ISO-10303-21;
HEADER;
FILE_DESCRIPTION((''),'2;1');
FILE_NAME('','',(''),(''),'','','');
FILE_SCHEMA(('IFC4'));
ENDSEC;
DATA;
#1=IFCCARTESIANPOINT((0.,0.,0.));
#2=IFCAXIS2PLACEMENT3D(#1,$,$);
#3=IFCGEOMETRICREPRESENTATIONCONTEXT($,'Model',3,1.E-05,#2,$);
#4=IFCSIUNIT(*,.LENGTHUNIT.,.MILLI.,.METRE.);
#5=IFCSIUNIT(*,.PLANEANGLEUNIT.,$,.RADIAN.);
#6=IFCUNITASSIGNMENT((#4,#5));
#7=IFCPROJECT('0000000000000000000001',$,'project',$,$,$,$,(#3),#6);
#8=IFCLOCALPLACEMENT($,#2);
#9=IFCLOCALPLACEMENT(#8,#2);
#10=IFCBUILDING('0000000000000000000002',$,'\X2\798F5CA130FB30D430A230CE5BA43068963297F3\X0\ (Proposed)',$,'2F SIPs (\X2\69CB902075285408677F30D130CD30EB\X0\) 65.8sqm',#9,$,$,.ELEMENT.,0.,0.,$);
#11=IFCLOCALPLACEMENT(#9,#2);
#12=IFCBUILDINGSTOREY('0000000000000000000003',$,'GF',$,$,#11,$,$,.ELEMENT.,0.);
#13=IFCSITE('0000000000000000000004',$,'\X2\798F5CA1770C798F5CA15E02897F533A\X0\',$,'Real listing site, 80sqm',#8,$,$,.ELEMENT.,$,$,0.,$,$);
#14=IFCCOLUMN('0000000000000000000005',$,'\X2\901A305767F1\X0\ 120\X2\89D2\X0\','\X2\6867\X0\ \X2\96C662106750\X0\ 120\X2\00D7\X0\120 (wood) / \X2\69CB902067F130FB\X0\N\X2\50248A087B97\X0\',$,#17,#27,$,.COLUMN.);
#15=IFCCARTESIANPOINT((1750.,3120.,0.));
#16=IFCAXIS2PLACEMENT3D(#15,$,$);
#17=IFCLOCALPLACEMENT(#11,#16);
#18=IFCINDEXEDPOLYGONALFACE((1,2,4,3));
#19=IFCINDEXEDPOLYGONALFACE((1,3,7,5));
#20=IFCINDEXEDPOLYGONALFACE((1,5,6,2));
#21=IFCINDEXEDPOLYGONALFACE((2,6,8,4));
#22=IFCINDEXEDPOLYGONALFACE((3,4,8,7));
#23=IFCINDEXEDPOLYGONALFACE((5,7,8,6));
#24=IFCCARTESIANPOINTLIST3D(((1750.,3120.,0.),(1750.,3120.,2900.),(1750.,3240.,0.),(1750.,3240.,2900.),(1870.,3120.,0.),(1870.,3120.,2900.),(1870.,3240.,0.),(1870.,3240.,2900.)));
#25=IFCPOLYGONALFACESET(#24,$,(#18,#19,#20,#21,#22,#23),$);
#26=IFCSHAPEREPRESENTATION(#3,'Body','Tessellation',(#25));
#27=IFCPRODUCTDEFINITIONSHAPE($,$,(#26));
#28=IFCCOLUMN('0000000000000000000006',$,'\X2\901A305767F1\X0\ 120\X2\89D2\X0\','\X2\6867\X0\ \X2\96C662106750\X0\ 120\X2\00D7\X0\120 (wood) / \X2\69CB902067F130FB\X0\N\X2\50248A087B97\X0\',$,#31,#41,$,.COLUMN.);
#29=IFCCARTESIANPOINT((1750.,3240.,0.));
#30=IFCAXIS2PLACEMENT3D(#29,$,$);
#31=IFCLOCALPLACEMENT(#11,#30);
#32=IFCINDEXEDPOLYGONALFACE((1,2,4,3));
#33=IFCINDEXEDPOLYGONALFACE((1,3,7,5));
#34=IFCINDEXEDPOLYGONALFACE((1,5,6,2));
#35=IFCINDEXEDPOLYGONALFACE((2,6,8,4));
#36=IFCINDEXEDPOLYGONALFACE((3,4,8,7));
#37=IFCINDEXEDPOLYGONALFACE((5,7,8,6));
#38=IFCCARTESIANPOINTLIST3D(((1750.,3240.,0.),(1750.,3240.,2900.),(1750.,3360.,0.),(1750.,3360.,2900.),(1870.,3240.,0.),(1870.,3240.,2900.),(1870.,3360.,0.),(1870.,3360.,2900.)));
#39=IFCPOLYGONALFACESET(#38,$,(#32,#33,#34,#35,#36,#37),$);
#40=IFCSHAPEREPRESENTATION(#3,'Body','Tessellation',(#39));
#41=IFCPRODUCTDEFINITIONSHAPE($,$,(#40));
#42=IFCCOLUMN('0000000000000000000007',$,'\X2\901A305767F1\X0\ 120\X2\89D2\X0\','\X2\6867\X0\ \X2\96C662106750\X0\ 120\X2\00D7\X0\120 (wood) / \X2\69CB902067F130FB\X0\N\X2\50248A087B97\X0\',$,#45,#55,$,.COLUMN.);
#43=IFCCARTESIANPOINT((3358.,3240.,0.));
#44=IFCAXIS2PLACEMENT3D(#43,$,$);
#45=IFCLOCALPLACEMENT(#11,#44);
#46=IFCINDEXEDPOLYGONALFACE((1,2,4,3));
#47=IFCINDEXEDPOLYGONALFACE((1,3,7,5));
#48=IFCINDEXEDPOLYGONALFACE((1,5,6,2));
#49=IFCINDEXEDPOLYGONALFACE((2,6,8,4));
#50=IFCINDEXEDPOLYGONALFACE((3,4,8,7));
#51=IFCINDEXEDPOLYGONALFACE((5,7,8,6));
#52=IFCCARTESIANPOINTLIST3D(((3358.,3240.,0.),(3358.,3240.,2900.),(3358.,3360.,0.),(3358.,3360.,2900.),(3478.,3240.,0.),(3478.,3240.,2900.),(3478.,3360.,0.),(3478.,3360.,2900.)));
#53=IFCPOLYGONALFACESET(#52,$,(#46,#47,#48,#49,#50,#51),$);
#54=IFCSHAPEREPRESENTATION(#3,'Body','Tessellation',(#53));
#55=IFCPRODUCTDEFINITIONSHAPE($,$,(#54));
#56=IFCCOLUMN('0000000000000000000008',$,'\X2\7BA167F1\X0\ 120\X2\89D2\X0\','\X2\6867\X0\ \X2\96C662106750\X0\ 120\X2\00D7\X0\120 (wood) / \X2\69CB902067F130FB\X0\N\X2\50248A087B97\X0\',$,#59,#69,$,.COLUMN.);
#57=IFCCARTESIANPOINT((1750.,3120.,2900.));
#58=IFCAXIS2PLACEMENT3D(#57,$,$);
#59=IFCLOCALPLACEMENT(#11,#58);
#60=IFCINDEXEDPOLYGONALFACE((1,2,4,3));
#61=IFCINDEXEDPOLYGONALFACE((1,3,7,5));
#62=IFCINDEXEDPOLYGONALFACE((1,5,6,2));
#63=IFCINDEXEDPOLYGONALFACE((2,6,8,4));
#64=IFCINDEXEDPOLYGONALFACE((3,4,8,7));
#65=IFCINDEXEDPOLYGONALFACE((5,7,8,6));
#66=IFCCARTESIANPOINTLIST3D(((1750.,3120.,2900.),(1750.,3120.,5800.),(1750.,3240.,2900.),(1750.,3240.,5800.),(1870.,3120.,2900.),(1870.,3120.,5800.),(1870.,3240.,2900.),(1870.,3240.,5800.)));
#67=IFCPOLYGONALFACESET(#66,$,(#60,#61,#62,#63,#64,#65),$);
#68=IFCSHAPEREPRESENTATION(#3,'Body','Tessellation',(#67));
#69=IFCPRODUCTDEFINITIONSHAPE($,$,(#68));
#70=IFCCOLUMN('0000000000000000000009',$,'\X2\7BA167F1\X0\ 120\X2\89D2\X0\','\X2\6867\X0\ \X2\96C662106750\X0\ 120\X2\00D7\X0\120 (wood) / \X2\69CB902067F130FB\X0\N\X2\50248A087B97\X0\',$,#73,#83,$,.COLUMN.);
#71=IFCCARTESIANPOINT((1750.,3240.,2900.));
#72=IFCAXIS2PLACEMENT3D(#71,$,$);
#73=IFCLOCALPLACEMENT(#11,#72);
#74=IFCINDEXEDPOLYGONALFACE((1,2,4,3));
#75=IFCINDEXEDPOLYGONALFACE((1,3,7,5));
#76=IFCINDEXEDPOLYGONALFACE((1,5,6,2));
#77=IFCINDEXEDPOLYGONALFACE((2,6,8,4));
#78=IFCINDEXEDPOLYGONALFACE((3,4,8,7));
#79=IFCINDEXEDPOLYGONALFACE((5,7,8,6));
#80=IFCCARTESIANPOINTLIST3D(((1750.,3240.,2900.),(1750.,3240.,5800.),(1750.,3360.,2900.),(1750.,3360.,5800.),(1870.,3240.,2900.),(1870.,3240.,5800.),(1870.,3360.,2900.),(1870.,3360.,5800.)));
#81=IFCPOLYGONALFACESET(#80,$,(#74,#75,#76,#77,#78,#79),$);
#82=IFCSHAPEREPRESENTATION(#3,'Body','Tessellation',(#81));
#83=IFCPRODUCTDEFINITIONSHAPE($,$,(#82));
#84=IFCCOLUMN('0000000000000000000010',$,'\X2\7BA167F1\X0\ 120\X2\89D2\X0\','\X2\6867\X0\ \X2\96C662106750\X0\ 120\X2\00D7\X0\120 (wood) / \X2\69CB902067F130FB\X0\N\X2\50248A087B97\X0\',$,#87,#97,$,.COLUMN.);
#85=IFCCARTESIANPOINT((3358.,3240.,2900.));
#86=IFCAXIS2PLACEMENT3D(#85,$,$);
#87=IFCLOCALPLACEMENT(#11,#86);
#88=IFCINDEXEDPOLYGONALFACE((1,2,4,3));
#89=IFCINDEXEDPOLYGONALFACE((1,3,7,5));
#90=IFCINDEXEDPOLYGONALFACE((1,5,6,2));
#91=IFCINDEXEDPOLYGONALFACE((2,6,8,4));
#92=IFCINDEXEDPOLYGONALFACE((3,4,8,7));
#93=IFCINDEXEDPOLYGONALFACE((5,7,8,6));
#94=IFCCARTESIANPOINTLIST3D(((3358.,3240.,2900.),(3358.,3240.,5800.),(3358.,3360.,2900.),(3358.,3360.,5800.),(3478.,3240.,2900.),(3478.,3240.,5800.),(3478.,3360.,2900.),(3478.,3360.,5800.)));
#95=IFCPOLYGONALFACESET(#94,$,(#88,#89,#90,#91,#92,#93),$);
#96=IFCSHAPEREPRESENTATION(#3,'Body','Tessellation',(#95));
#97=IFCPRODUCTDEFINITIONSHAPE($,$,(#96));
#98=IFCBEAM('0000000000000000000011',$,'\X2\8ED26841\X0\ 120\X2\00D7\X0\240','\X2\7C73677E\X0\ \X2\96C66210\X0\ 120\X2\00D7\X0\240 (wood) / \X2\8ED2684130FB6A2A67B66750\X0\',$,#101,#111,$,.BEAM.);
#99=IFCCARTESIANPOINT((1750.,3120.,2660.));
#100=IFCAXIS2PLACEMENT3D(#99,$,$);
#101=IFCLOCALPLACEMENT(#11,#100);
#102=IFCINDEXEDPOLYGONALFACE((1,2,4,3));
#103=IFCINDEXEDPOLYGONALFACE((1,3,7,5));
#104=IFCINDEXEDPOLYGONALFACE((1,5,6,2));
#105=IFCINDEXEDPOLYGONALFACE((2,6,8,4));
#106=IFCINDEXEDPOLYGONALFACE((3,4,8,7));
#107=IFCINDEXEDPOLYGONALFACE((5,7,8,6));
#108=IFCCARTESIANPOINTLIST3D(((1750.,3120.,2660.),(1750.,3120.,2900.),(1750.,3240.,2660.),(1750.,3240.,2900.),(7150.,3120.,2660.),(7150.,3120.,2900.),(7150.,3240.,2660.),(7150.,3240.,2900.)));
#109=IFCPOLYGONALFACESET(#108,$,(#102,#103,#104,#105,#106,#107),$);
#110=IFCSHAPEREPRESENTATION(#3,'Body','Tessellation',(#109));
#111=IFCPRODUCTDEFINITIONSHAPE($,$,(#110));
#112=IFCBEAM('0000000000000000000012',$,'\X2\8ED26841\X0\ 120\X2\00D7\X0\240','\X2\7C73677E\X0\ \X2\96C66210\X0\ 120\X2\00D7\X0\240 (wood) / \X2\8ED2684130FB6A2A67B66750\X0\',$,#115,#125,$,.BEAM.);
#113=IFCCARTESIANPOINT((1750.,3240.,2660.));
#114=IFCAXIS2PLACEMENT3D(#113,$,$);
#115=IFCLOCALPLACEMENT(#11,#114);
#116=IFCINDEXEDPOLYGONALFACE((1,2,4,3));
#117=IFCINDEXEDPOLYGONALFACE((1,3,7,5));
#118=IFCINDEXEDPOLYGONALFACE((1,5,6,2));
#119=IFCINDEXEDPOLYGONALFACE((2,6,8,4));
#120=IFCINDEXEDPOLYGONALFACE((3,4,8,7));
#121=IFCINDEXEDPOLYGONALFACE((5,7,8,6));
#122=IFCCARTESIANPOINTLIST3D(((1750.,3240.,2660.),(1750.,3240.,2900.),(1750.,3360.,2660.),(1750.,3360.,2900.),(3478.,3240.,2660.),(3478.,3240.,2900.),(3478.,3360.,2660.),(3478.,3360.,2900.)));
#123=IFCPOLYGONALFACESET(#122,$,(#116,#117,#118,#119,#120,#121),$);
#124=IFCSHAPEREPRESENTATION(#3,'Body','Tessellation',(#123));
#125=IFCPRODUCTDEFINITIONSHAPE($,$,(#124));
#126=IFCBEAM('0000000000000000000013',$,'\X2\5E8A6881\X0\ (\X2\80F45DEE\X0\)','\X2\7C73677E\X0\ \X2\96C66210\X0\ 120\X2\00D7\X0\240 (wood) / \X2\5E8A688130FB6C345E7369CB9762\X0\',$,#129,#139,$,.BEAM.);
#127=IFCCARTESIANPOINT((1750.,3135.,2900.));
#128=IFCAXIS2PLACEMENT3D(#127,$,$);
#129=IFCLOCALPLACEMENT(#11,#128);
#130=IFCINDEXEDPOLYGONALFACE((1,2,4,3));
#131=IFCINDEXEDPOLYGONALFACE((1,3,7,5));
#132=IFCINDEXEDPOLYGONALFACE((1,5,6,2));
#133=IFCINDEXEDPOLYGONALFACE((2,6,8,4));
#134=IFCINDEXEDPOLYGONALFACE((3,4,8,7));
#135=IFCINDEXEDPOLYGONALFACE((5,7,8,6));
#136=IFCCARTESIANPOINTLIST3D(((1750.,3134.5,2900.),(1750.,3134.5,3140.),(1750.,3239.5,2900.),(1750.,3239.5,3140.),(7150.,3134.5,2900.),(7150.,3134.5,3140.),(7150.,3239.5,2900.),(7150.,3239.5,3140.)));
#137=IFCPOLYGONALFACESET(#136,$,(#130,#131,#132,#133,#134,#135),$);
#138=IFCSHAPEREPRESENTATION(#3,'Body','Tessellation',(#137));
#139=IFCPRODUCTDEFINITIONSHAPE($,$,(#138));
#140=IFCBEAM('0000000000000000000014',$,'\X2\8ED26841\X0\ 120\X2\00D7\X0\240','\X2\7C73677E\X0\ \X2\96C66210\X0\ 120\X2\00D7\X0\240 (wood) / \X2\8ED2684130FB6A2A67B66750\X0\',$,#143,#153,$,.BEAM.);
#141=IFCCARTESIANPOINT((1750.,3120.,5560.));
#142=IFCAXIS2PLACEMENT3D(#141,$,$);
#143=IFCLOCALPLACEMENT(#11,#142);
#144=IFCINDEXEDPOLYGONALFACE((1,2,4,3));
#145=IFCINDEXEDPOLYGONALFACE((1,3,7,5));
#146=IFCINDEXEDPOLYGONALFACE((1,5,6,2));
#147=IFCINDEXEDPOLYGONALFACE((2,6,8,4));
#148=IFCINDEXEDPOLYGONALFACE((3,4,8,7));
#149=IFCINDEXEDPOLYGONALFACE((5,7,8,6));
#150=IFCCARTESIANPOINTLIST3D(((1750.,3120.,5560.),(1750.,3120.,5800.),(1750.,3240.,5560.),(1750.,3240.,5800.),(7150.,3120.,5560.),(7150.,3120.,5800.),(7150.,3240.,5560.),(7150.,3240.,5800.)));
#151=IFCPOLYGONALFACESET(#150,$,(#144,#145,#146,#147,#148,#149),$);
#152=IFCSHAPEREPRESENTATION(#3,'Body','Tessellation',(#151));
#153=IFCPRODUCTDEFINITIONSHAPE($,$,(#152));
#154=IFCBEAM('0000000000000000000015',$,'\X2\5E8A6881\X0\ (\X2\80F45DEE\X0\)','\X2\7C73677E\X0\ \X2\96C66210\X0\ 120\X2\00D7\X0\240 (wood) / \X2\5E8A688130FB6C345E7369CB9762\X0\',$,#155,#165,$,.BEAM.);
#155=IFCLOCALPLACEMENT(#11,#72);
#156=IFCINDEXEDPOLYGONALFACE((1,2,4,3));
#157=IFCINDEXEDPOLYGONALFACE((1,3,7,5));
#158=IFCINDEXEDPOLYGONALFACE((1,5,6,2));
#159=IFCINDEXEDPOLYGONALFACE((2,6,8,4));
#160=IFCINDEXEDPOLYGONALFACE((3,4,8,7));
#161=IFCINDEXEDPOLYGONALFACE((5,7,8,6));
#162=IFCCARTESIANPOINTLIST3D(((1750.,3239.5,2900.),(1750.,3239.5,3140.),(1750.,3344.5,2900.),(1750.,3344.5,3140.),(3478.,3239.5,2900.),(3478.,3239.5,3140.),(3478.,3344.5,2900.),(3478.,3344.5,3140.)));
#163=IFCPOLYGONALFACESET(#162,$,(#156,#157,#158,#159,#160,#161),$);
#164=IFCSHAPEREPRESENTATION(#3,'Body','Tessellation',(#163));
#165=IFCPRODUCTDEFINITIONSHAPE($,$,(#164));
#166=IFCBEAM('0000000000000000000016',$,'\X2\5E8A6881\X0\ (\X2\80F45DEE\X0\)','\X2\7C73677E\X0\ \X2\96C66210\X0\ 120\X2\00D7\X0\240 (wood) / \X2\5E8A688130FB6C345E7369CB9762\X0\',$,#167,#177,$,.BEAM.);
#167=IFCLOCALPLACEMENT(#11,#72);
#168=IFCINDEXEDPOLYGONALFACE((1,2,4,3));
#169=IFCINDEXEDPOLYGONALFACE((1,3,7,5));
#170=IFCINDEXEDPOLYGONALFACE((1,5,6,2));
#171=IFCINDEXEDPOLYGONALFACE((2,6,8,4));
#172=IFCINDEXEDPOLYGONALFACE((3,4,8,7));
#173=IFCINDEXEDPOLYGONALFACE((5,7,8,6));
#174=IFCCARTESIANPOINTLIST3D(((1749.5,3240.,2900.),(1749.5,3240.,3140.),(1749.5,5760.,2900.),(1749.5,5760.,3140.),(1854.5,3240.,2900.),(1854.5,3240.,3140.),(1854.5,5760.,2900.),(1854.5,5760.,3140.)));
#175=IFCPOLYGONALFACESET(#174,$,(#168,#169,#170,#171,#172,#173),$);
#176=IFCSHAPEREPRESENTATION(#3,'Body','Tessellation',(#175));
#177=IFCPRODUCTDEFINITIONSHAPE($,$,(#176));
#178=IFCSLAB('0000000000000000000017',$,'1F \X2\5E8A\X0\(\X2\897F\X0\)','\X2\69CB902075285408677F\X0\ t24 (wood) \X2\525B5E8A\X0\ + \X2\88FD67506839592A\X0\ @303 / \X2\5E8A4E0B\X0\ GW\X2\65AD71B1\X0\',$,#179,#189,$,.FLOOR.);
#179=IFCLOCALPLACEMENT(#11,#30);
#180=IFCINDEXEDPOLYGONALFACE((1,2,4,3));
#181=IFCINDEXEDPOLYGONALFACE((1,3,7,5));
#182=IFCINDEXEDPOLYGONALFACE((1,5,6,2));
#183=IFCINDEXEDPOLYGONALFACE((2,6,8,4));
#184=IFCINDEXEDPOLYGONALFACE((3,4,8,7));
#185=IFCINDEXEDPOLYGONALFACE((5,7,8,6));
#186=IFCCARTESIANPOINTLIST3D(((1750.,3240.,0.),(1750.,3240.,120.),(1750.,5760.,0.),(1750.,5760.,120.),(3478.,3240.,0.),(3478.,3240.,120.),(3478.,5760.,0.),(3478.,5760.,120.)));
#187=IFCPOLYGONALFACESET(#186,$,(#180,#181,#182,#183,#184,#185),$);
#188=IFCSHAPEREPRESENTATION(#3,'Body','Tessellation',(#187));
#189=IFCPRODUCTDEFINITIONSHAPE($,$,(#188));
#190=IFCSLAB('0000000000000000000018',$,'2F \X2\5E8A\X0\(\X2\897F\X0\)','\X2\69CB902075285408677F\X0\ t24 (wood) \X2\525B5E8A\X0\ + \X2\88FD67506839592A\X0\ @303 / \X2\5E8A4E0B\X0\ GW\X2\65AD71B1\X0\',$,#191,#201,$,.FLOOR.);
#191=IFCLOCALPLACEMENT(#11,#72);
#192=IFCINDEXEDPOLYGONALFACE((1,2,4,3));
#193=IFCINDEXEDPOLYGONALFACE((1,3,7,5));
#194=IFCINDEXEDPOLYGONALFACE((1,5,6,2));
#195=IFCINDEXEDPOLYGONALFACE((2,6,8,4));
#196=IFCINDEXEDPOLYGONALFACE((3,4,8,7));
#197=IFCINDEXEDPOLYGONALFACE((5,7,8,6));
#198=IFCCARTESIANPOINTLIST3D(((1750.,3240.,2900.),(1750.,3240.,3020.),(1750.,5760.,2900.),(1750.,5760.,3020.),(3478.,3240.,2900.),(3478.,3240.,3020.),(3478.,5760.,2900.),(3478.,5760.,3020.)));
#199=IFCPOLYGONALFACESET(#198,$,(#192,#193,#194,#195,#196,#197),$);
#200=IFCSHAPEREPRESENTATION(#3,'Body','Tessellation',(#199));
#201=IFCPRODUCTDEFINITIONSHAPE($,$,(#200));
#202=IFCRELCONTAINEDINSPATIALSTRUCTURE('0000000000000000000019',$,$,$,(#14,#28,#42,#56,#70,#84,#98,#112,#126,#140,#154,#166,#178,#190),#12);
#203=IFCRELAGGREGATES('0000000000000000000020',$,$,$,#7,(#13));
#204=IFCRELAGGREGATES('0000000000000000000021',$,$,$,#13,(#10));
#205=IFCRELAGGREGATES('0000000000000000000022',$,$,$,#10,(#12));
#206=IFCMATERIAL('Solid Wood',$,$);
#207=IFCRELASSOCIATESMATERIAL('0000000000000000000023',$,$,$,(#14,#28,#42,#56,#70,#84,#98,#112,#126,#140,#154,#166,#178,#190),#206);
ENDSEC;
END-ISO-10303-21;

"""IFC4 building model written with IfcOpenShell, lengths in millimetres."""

from ifc_helpers import new_model, si_unit, frame, frame_2d, origin, place, context, project, spatial, rectangle, extrude, material, element, save


model = new_model("IFC4")

# Units and contexts
model_context = context("Model", 3, precision=1e-05, world=origin())
ifc_project = project(units=[si_unit("LENGTHUNIT", "METRE", prefix="MILLI"), si_unit("PLANEANGLEUNIT", "RADIAN")], contexts=[model_context])

# Site, building, storey
site_placement = place(None, origin())
site = spatial("IfcSite", under=ifc_project, at=site_placement, Name="福岡県福岡市西区", ObjectType="Real listing site, 80sqm", CompositionType="ELEMENT", RefElevation=0.0)
building_placement = place(site_placement, origin())
building = spatial("IfcBuilding", under=site, at=building_placement, Name="福岡・ピアノ室と防音 (Proposed)", ObjectType="2F SIPs (構造用合板パネル) 65.8sqm", CompositionType="ELEMENT", ElevationOfRefHeight=0.0, ElevationOfTerrain=0.0)
storey_placement = place(building_placement, origin())
storey = spatial("IfcBuildingStorey", under=building, at=storey_placement, Name="GF", CompositionType="ELEMENT", Elevation=0.0)

# Columns
ifc_material_1 = material(Name="Solid Wood")
column_1_placement = place(storey_placement, frame((1750.0, 3120.0, 0.0)))
element("IfcColumn", 1, at=column_1_placement, inside=storey, material=ifc_material_1, Name="通し柱 120角", Description="桧 集成材 120×120 (wood) / 構造柱・N値計算", PredefinedType="COLUMN", context=model_context, shape_type="SweptSolid", body=[
    extrude(rectangle(XDim=120.0, YDim=120.0, at=frame_2d((60.0, 60.0))), frame((1750.0, 3120.0, 0.0)), (0.0, 0.0, 1.0), 2900.0),
])
column_2_placement = place(storey_placement, frame((1750.0, 3240.0, 0.0)))
element("IfcColumn", 2, at=column_2_placement, inside=storey, material=ifc_material_1, Name="通し柱 120角", Description="桧 集成材 120×120 (wood) / 構造柱・N値計算", PredefinedType="COLUMN", context=model_context, shape_type="SweptSolid", body=[
    extrude(rectangle(XDim=120.0, YDim=120.0, at=frame_2d((60.0, 60.0))), frame((1750.0, 3240.0, 0.0)), (0.0, 0.0, 1.0), 2900.0),
])
column_3_placement = place(storey_placement, frame((3358.0, 3240.0, 0.0)))
element("IfcColumn", 3, at=column_3_placement, inside=storey, material=ifc_material_1, Name="通し柱 120角", Description="桧 集成材 120×120 (wood) / 構造柱・N値計算", PredefinedType="COLUMN", context=model_context, shape_type="SweptSolid", body=[
    extrude(rectangle(XDim=120.0, YDim=120.0, at=frame_2d((60.0, 60.0))), frame((3358.0, 3240.0, 0.0)), (0.0, 0.0, 1.0), 2900.0),
])
column_4_placement = place(storey_placement, frame((1750.0, 3120.0, 2900.0)))
element("IfcColumn", 4, at=column_4_placement, inside=storey, material=ifc_material_1, Name="管柱 120角", Description="桧 集成材 120×120 (wood) / 構造柱・N値計算", PredefinedType="COLUMN", context=model_context, shape_type="SweptSolid", body=[
    extrude(rectangle(XDim=120.0, YDim=120.0, at=frame_2d((60.0, 60.0))), frame((1750.0, 3120.0, 2900.0)), (0.0, 0.0, 1.0), 2900.0),
])
column_5_placement = place(storey_placement, frame((1750.0, 3240.0, 2900.0)))
element("IfcColumn", 5, at=column_5_placement, inside=storey, material=ifc_material_1, Name="管柱 120角", Description="桧 集成材 120×120 (wood) / 構造柱・N値計算", PredefinedType="COLUMN", context=model_context, shape_type="SweptSolid", body=[
    extrude(rectangle(XDim=120.0, YDim=120.0, at=frame_2d((60.0, 60.0))), frame((1750.0, 3240.0, 2900.0)), (0.0, 0.0, 1.0), 2900.0),
])
column_6_placement = place(storey_placement, frame((3358.0, 3240.0, 2900.0)))
element("IfcColumn", 6, at=column_6_placement, inside=storey, material=ifc_material_1, Name="管柱 120角", Description="桧 集成材 120×120 (wood) / 構造柱・N値計算", PredefinedType="COLUMN", context=model_context, shape_type="SweptSolid", body=[
    extrude(rectangle(XDim=120.0, YDim=120.0, at=frame_2d((60.0, 60.0))), frame((3358.0, 3240.0, 2900.0)), (0.0, 0.0, 1.0), 2900.0),
])

# Beams
beam_1_placement = place(storey_placement, frame((1750.0, 3120.0, 2660.0)))
element("IfcBeam", 7, at=beam_1_placement, inside=storey, material=ifc_material_1, Name="軒桁 120×240", Description="米松 集成 120×240 (wood) / 軒桁・横架材", PredefinedType="BEAM", context=model_context, shape_type="SweptSolid", body=[
    extrude(rectangle(XDim=5400.0, YDim=120.0, at=frame_2d((2700.0, 60.0))), frame((1750.0, 3120.0, 2660.0)), (0.0, 0.0, 1.0), 240.0),
])
beam_2_placement = place(storey_placement, frame((1750.0, 3240.0, 2660.0)))
element("IfcBeam", 8, at=beam_2_placement, inside=storey, material=ifc_material_1, Name="軒桁 120×240", Description="米松 集成 120×240 (wood) / 軒桁・横架材", PredefinedType="BEAM", context=model_context, shape_type="SweptSolid", body=[
    extrude(rectangle(XDim=1728.0, YDim=120.0, at=frame_2d((864.0, 60.0))), frame((1750.0, 3240.0, 2660.0)), (0.0, 0.0, 1.0), 240.0),
])
beam_3_placement = place(storey_placement, frame((1750.0, 3135.0, 2900.0)))
element("IfcBeam", 9, at=beam_3_placement, inside=storey, material=ifc_material_1, Name="床梁 (胴差)", Description="米松 集成 120×240 (wood) / 床梁・水平構面", PredefinedType="BEAM", context=model_context, shape_type="SweptSolid", body=[
    extrude(rectangle(XDim=5400.0, YDim=105.0, at=frame_2d((2700.0, 52.0))), frame((1750.0, 3135.0, 2900.0)), (0.0, 0.0, 1.0), 240.0),
])
beam_4_placement = place(storey_placement, frame((1750.0, 3120.0, 5560.0)))
element("IfcBeam", 10, at=beam_4_placement, inside=storey, material=ifc_material_1, Name="軒桁 120×240", Description="米松 集成 120×240 (wood) / 軒桁・横架材", PredefinedType="BEAM", context=model_context, shape_type="SweptSolid", body=[
    extrude(rectangle(XDim=5400.0, YDim=120.0, at=frame_2d((2700.0, 60.0))), frame((1750.0, 3120.0, 5560.0)), (0.0, 0.0, 1.0), 240.0),
])
beam_5_placement = place(storey_placement, frame((1750.0, 3240.0, 2900.0)))
element("IfcBeam", 11, at=beam_5_placement, inside=storey, material=ifc_material_1, Name="床梁 (胴差)", Description="米松 集成 120×240 (wood) / 床梁・水平構面", PredefinedType="BEAM", context=model_context, shape_type="SweptSolid", body=[
    extrude(rectangle(XDim=1728.0, YDim=105.0, at=frame_2d((864.0, 52.0))), frame((1750.0, 3240.0, 2900.0)), (0.0, 0.0, 1.0), 240.0),
])
beam_6_placement = place(storey_placement, frame((1750.0, 3240.0, 2900.0)))
element("IfcBeam", 12, at=beam_6_placement, inside=storey, material=ifc_material_1, Name="床梁 (胴差)", Description="米松 集成 120×240 (wood) / 床梁・水平構面", PredefinedType="BEAM", context=model_context, shape_type="SweptSolid", body=[
    extrude(rectangle(XDim=105.0, YDim=2520.0, at=frame_2d((52.0, 1260.0))), frame((1750.0, 3240.0, 2900.0)), (0.0, 0.0, 1.0), 240.0),
])

# Slabs
slab_1_placement = place(storey_placement, frame((1750.0, 3240.0, 0.0)))
element("IfcSlab", 13, at=slab_1_placement, inside=storey, material=ifc_material_1, Name="1F 床(西)", Description="構造用合板 t24 (wood) 剛床 + 製材根太 @303 / 床下 GW断熱", PredefinedType="FLOOR", context=model_context, shape_type="SweptSolid", body=[
    extrude(rectangle(XDim=1728.0, YDim=2520.0, at=frame_2d((864.0, 1260.0))), frame((1750.0, 3240.0, 0.0)), (0.0, 0.0, 1.0), 120.0),
])
slab_2_placement = place(storey_placement, frame((1750.0, 3240.0, 2900.0)))
element("IfcSlab", 14, at=slab_2_placement, inside=storey, material=ifc_material_1, Name="2F 床(西)", Description="構造用合板 t24 (wood) 剛床 + 製材根太 @303 / 床下 GW断熱", PredefinedType="FLOOR", context=model_context, shape_type="SweptSolid", body=[
    extrude(rectangle(XDim=1728.0, YDim=2520.0, at=frame_2d((864.0, 1260.0))), frame((1750.0, 3240.0, 2900.0)), (0.0, 0.0, 1.0), 120.0),
])

save(model, "model.ifc")
